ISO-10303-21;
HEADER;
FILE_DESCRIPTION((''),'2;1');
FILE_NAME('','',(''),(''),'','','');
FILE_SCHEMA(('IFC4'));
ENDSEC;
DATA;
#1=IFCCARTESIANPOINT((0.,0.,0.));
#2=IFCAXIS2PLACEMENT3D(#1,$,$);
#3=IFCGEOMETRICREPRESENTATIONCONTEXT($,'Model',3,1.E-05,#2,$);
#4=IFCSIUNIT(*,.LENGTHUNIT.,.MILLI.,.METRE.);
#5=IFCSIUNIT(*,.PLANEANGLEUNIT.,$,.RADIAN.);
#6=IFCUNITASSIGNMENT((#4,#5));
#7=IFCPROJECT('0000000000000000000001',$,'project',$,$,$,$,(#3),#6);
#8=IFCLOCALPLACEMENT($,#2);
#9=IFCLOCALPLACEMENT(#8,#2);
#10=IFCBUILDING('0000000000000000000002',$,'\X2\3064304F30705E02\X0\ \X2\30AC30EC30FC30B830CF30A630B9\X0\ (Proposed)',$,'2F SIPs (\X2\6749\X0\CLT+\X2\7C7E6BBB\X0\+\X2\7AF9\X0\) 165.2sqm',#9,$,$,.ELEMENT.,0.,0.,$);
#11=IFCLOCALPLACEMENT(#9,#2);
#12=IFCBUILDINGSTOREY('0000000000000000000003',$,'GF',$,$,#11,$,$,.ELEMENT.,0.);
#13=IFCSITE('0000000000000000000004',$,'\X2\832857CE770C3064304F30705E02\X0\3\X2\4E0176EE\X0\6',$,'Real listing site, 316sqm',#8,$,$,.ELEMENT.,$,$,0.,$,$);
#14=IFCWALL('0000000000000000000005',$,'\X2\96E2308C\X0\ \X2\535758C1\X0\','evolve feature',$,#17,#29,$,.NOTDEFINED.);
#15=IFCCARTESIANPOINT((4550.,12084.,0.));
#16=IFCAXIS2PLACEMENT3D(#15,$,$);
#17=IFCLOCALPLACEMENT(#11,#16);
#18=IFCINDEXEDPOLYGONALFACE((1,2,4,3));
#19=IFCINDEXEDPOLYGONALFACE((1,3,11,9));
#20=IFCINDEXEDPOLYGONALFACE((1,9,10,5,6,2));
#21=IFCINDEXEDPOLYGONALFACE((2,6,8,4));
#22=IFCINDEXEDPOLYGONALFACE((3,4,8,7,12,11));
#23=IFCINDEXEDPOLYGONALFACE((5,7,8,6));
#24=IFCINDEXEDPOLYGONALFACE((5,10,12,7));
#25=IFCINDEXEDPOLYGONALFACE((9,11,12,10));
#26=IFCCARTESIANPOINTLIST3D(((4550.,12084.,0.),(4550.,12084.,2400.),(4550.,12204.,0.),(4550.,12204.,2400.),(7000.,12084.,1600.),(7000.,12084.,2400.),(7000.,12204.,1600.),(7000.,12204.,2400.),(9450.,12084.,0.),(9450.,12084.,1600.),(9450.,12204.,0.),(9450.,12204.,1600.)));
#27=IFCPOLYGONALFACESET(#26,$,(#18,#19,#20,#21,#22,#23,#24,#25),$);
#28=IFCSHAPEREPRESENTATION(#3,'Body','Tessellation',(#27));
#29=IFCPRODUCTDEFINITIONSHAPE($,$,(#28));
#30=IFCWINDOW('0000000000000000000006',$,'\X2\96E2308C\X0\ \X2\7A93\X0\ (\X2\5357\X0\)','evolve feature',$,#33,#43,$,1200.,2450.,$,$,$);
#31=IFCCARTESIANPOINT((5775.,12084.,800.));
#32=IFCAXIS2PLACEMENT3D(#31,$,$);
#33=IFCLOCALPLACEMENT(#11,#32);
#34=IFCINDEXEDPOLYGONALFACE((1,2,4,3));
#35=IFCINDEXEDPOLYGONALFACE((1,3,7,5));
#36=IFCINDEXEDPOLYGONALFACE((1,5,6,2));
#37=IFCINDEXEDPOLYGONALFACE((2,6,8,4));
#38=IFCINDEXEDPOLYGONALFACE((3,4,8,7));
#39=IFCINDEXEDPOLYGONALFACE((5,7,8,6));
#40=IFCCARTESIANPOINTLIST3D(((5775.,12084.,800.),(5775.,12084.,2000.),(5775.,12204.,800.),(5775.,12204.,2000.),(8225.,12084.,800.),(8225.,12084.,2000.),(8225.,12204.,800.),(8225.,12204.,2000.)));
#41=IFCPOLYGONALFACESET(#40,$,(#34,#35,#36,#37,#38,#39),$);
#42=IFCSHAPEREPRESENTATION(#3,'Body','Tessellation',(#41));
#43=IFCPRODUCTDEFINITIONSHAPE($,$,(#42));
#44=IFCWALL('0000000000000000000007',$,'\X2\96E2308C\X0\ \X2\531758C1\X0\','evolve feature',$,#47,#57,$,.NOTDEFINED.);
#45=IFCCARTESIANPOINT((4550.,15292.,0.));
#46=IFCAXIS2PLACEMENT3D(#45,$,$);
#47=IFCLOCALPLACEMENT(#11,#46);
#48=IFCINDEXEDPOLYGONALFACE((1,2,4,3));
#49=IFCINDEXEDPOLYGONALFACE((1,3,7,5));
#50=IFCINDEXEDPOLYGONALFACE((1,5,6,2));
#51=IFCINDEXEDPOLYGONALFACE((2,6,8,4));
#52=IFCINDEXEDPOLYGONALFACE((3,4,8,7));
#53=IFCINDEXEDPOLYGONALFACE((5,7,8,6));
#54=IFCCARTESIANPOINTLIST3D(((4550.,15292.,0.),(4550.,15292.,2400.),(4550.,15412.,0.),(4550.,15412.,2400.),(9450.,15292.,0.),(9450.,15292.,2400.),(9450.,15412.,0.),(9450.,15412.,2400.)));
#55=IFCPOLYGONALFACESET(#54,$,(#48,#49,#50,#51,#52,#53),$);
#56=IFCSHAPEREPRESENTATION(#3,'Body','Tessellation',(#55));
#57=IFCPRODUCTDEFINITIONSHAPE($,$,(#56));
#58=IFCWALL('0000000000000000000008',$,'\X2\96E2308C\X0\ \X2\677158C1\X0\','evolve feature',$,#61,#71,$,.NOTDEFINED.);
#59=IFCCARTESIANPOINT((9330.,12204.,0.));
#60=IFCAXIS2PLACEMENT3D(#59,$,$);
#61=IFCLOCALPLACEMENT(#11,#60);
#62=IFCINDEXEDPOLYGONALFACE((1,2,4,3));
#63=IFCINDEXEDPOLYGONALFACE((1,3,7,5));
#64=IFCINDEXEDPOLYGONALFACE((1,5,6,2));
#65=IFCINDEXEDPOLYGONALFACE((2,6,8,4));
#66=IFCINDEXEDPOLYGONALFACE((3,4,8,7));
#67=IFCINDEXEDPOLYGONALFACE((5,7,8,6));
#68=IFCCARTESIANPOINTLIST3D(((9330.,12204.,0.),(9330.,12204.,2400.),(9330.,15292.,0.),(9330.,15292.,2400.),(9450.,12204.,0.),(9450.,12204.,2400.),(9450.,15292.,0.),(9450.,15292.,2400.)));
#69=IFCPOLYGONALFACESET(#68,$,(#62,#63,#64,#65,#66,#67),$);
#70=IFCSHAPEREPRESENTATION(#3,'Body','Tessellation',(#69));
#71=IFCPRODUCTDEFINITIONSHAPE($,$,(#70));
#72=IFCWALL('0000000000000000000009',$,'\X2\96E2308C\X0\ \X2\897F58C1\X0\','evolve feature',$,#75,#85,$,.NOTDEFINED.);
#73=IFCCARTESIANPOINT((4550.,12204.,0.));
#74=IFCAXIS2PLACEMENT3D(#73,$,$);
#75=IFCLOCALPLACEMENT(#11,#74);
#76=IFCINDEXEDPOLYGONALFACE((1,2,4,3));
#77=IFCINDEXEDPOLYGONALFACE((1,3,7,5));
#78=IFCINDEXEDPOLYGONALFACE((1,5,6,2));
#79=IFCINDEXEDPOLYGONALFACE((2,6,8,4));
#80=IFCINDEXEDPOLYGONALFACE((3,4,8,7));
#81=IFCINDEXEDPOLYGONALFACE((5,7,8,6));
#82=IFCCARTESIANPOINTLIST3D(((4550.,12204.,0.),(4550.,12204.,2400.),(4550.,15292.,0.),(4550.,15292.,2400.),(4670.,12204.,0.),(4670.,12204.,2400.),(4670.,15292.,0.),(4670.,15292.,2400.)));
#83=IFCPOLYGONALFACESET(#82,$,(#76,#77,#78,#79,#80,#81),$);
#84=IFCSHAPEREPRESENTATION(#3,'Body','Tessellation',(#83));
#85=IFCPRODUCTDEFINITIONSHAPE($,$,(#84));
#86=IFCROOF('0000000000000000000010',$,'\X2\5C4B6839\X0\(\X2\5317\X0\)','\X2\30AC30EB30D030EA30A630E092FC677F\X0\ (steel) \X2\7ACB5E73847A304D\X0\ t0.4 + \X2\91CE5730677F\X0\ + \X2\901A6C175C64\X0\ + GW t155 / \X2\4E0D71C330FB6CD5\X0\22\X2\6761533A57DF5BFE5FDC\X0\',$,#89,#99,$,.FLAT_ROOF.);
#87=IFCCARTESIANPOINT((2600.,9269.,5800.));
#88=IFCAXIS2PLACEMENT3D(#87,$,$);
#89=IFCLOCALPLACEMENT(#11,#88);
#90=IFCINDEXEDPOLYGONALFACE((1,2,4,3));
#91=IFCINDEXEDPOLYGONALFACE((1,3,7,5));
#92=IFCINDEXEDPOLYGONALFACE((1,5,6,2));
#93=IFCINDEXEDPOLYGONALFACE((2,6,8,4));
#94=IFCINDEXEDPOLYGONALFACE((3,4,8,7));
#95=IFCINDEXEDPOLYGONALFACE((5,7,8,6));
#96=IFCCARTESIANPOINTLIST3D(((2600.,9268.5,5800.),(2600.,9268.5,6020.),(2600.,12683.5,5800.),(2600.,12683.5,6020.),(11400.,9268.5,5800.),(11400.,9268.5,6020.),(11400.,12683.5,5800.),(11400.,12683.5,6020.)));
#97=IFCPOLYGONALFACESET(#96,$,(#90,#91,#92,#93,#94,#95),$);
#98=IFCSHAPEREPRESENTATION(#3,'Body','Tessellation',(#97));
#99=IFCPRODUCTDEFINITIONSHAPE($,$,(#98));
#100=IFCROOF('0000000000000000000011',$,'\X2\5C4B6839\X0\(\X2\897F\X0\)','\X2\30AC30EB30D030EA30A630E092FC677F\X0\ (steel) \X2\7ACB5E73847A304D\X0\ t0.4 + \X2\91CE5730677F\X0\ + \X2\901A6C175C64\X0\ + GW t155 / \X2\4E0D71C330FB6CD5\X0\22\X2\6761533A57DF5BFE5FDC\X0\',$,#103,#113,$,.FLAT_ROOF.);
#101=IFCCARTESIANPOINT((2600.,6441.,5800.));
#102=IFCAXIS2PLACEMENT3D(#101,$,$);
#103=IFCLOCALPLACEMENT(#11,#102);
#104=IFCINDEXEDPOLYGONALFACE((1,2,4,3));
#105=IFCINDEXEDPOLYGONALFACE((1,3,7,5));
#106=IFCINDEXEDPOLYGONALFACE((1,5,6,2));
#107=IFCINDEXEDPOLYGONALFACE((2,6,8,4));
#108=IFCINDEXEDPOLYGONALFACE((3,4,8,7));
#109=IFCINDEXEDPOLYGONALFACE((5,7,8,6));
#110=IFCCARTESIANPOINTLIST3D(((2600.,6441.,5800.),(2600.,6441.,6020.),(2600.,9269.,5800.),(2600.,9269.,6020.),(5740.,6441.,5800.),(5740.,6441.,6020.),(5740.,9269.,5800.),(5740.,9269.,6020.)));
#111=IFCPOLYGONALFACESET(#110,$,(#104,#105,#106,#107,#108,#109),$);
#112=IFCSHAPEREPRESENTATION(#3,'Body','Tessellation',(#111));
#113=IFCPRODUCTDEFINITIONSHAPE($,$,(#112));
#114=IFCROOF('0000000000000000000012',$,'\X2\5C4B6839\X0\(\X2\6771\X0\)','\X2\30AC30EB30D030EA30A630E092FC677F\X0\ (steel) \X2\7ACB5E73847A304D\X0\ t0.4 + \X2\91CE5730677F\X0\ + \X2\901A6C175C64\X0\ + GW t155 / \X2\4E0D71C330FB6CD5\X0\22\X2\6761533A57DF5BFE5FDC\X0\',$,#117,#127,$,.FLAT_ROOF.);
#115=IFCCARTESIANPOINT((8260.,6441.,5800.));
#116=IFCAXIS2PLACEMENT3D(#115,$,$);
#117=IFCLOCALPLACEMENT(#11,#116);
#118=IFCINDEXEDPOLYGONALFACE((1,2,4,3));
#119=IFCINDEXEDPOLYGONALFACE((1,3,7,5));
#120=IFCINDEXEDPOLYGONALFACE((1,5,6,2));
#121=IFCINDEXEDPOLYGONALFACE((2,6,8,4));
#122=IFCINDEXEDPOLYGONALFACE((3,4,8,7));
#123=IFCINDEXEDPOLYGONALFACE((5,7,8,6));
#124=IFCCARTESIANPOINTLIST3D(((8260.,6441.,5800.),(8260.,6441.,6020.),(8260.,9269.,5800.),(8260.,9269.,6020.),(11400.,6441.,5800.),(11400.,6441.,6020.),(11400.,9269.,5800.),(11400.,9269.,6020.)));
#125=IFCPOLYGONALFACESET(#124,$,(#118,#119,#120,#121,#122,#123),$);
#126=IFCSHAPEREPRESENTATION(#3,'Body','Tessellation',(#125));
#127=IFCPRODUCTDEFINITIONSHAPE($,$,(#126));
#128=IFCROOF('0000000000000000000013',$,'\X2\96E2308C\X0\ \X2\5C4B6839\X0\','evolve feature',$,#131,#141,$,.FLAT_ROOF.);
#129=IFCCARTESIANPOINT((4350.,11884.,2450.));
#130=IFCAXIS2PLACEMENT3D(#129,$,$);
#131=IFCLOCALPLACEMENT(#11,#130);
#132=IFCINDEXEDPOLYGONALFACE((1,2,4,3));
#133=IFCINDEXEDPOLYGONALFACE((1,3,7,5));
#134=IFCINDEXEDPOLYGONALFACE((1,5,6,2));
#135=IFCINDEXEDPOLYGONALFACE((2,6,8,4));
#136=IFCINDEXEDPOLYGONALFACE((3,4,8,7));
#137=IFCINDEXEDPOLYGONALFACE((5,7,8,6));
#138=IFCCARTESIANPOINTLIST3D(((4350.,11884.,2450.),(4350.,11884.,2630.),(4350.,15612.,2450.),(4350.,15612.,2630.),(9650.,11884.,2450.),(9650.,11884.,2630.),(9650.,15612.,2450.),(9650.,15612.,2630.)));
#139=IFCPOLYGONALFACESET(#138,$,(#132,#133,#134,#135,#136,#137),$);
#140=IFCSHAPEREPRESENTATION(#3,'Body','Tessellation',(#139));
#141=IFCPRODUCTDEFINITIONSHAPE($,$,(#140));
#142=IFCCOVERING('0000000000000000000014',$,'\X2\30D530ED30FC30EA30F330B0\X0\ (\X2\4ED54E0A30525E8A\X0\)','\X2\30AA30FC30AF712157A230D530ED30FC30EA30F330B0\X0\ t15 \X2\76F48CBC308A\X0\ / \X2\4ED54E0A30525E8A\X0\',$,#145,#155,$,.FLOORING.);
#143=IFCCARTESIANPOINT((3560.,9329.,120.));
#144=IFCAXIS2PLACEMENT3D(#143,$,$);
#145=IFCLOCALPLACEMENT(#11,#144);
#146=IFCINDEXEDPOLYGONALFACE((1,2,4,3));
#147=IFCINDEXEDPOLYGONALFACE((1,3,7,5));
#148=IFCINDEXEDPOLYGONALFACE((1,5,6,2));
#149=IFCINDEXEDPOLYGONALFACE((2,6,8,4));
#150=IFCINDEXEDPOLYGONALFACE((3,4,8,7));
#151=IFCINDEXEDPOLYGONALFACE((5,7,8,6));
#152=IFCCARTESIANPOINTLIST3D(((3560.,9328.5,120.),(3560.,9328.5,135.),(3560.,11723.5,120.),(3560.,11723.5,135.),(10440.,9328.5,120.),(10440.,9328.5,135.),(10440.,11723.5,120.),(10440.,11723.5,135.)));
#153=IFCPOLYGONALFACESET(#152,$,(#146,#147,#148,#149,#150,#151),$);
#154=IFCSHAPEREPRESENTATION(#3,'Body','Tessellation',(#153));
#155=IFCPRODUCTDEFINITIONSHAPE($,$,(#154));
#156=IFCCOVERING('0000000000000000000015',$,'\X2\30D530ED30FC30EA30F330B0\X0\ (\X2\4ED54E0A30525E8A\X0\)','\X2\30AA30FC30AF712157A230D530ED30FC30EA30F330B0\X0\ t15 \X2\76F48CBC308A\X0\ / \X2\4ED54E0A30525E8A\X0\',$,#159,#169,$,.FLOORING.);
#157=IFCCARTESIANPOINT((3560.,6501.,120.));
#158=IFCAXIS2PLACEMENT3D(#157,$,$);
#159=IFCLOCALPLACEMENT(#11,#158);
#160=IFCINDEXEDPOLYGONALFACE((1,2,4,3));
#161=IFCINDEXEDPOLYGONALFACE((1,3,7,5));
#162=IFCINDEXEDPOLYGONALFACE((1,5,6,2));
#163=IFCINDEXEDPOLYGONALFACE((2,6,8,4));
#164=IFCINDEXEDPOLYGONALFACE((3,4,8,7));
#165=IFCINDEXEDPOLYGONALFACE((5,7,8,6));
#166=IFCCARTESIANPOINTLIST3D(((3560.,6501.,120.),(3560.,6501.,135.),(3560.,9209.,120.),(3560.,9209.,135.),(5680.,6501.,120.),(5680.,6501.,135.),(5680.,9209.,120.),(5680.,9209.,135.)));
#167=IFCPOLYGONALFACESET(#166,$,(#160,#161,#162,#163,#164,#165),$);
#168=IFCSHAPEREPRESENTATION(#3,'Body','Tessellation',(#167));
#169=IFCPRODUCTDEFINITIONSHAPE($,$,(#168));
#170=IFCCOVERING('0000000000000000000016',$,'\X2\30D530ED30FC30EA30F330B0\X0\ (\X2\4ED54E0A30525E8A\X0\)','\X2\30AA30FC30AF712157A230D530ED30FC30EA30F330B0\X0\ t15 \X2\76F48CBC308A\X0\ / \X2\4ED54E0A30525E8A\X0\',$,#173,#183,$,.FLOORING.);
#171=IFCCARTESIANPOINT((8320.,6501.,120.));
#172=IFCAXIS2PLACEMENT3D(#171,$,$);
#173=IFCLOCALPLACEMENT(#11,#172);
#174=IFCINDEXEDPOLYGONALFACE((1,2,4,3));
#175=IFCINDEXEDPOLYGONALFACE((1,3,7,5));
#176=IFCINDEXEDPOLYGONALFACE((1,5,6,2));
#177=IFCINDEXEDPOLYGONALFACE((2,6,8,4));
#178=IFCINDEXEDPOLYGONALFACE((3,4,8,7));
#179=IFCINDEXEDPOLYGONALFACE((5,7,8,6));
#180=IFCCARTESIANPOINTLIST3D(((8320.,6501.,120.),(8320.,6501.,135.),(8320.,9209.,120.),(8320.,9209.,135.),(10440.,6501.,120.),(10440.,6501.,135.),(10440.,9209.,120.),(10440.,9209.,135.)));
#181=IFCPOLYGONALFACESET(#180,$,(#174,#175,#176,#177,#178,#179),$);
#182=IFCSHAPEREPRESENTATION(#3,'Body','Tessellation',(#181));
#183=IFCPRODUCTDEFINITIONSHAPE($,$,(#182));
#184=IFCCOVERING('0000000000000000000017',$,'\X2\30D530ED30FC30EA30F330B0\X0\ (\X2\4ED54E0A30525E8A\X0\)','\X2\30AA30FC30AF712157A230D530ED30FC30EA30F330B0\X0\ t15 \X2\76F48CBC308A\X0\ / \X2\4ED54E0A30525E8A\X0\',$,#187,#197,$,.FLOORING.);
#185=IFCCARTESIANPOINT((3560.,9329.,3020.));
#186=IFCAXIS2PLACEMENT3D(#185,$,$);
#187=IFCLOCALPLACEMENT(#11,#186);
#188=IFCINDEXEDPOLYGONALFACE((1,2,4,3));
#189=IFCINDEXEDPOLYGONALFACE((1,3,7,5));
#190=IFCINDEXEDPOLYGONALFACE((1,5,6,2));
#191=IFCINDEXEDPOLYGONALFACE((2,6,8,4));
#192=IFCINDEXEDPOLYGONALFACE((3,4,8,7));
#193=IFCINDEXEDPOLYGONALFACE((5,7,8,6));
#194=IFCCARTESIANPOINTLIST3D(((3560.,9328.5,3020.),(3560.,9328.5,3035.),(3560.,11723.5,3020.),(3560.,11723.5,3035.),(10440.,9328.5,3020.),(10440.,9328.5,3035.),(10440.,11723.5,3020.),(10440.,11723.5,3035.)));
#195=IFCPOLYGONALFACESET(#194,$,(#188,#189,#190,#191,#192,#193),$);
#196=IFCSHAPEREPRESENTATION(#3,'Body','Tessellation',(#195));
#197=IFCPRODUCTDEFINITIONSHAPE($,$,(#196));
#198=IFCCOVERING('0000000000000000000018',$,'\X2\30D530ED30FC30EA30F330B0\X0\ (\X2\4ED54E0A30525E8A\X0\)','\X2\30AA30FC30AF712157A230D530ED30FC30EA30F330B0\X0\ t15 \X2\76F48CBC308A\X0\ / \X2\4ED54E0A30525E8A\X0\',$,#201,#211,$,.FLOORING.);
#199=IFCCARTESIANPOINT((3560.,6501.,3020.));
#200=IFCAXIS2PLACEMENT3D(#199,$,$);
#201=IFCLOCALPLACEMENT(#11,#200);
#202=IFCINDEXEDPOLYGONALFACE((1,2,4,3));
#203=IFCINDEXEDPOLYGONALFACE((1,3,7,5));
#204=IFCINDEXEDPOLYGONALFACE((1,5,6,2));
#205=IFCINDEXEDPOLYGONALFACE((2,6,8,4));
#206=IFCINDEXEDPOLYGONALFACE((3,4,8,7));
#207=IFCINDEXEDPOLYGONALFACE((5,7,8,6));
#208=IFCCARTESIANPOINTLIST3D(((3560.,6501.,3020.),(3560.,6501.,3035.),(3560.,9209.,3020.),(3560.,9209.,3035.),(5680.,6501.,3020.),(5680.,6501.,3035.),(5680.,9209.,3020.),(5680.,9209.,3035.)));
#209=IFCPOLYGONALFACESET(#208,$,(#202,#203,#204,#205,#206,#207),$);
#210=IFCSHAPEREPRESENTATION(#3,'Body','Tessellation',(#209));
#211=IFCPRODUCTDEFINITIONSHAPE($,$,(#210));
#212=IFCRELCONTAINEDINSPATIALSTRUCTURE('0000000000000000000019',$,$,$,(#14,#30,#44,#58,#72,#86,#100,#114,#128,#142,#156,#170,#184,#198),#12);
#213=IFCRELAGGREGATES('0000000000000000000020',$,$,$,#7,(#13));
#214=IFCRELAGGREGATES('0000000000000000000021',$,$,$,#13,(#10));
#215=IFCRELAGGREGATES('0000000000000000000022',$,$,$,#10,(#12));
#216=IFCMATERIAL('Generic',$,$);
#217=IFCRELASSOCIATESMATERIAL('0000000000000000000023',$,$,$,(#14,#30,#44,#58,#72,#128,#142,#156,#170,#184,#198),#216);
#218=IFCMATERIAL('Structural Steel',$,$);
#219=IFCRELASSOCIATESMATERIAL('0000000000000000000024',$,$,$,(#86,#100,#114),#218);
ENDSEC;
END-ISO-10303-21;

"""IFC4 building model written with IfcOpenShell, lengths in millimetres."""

from ifc_helpers import new_model, si_unit, frame, frame_2d, origin, place, context, project, spatial, rectangle, extrude, material, element, fill, save


model = new_model("IFC4")

# Units and contexts
model_context = context("Model", 3, precision=1e-05, world=origin())
ifc_project = project(units=[si_unit("LENGTHUNIT", "METRE", prefix="MILLI"), si_unit("PLANEANGLEUNIT", "RADIAN")], contexts=[model_context])

# Site, building, storey
site_placement = place(None, origin())
site = spatial("IfcSite", under=ifc_project, at=site_placement, Name="茨城県つくば市3丁目6", ObjectType="Real listing site, 316sqm", CompositionType="ELEMENT", RefElevation=0.0)
building_placement = place(site_placement, origin())
building = spatial("IfcBuilding", under=site, at=building_placement, Name="つくば市 ガレージハウス (Proposed)", ObjectType="2F SIPs (杉CLT+籾殻+竹) 165.2sqm", CompositionType="ELEMENT", ElevationOfRefHeight=0.0, ElevationOfTerrain=0.0)
storey_placement = place(building_placement, origin())
storey = spatial("IfcBuildingStorey", under=building, at=storey_placement, Name="GF", CompositionType="ELEMENT", Elevation=0.0)

# Shared definitions
ifc_material_1 = material(Name="Generic")

# Wall, opening, window
wall_1_placement = place(storey_placement, frame((4550.0, 12084.0, 0.0)))
wall_1 = element("IfcWall", 1, at=wall_1_placement, inside=storey, material=ifc_material_1, Name="離れ 南壁", Description="evolve feature", PredefinedType="NOTDEFINED", context=model_context, shape_type="SweptSolid", body=[
    extrude(rectangle(XDim=4900.0, YDim=120.0, at=frame_2d((2450.0, 60.0))), frame((4550.0, 12084.0, 0.0)), (0.0, 0.0, 1.0), 2400.0),
])
opening_1_placement = place(storey_placement, frame((5775.0, 12084.0, 800.0)))
opening_1 = element("IfcOpeningElement", 2, at=opening_1_placement, cuts=wall_1, PredefinedType="NOTDEFINED", context=model_context, shape_type="SweptSolid", body=[
    extrude(rectangle(XDim=2450.0, YDim=120.0, at=frame_2d((1225.0, 60.0))), frame((5775.0, 12084.0, 800.0)), (0.0, 0.0, 1.0), 1200.0),
])
window_1_placement = place(storey_placement, frame((5775.0, 12084.0, 800.0)))
window_1 = element("IfcWindow", 3, at=window_1_placement, inside=storey, material=ifc_material_1, Name="離れ 窓 (南)", Description="evolve feature", OverallHeight=1200.0, OverallWidth=2450.0, context=model_context, shape_type="SweptSolid", body=[
    extrude(rectangle(XDim=2450.0, YDim=120.0, at=frame_2d((1225.0, 60.0))), frame((5775.0, 12084.0, 800.0)), (0.0, 0.0, 1.0), 1200.0),
])
fill(opening_1, window_1)

# Walls
wall_2_placement = place(storey_placement, frame((4550.0, 15292.0, 0.0)))
element("IfcWall", 4, at=wall_2_placement, inside=storey, material=ifc_material_1, Name="離れ 北壁", Description="evolve feature", PredefinedType="NOTDEFINED", context=model_context, shape_type="SweptSolid", body=[
    extrude(rectangle(XDim=4900.0, YDim=120.0, at=frame_2d((2450.0, 60.0))), frame((4550.0, 15292.0, 0.0)), (0.0, 0.0, 1.0), 2400.0),
])
wall_3_placement = place(storey_placement, frame((9330.0, 12204.0, 0.0)))
element("IfcWall", 5, at=wall_3_placement, inside=storey, material=ifc_material_1, Name="離れ 東壁", Description="evolve feature", PredefinedType="NOTDEFINED", context=model_context, shape_type="SweptSolid", body=[
    extrude(rectangle(XDim=120.0, YDim=3088.0, at=frame_2d((60.0, 1544.0))), frame((9330.0, 12204.0, 0.0)), (0.0, 0.0, 1.0), 2400.0),
])
wall_4_placement = place(storey_placement, frame((4550.0, 12204.0, 0.0)))
element("IfcWall", 6, at=wall_4_placement, inside=storey, material=ifc_material_1, Name="離れ 西壁", Description="evolve feature", PredefinedType="NOTDEFINED", context=model_context, shape_type="SweptSolid", body=[
    extrude(rectangle(XDim=120.0, YDim=3088.0, at=frame_2d((60.0, 1544.0))), frame((4550.0, 12204.0, 0.0)), (0.0, 0.0, 1.0), 2400.0),
])

# Roofs
ifc_material_2 = material(Name="Structural Steel")
for number, where, name in (
    (7, (2600.0, 9269.0, 5800.0), "屋根(北)"),
):
    element("IfcRoof", number, at=place(storey_placement, frame(where)), inside=storey, material=ifc_material_2, Name=name, Description="ガルバリウム鋼板 (steel) 立平葺き t0.4 + 野地板 + 通気層 + GW t155 / 不燃・法22条区域対応", PredefinedType="FLAT_ROOF", context=model_context, shape_type="SweptSolid", body=[
        extrude(rectangle(XDim=8800.0, YDim=3415.0, at=frame_2d((4400.0, 1707.0))), frame((2600.0, 9269.0, 5800.0)), (0.0, 0.0, 1.0), 220.0),
    ])
roof_1_placement = place(storey_placement, frame((2600.0, 6441.0, 5800.0)))
element("IfcRoof", 8, at=roof_1_placement, inside=storey, material=ifc_material_2, Name="屋根(西)", Description="ガルバリウム鋼板 (steel) 立平葺き t0.4 + 野地板 + 通気層 + GW t155 / 不燃・法22条区域対応", PredefinedType="FLAT_ROOF", context=model_context, shape_type="SweptSolid", body=[
    extrude(rectangle(XDim=3140.0, YDim=2828.0, at=frame_2d((1570.0, 1414.0))), frame((2600.0, 6441.0, 5800.0)), (0.0, 0.0, 1.0), 220.0),
])
roof_2_placement = place(storey_placement, frame((8260.0, 6441.0, 5800.0)))
element("IfcRoof", 9, at=roof_2_placement, inside=storey, material=ifc_material_2, Name="屋根(東)", Description="ガルバリウム鋼板 (steel) 立平葺き t0.4 + 野地板 + 通気層 + GW t155 / 不燃・法22条区域対応", PredefinedType="FLAT_ROOF", context=model_context, shape_type="SweptSolid", body=[
    extrude(rectangle(XDim=3140.0, YDim=2828.0, at=frame_2d((1570.0, 1414.0))), frame((8260.0, 6441.0, 5800.0)), (0.0, 0.0, 1.0), 220.0),
])
roof_3_placement = place(storey_placement, frame((4350.0, 11884.0, 2450.0)))
element("IfcRoof", 10, at=roof_3_placement, inside=storey, material=ifc_material_1, Name="離れ 屋根", Description="evolve feature", PredefinedType="FLAT_ROOF", context=model_context, shape_type="SweptSolid", body=[
    extrude(rectangle(XDim=5300.0, YDim=3728.0, at=frame_2d((2650.0, 1864.0))), frame((4350.0, 11884.0, 2450.0)), (0.0, 0.0, 1.0), 180.0),
])

# Coverings
covering_1_placement = place(storey_placement, frame((3560.0, 9329.0, 120.0)))
element("IfcCovering", 11, at=covering_1_placement, inside=storey, material=ifc_material_1, Name="フローリング (仕上げ床)", Description="オーク無垢フローリング t15 直貼り / 仕上げ床", PredefinedType="FLOORING", context=model_context, shape_type="SweptSolid", body=[
    extrude(rectangle(XDim=6880.0, YDim=2395.0, at=frame_2d((3440.0, 1197.0))), frame((3560.0, 9329.0, 120.0)), (0.0, 0.0, 1.0), 15.0),
])
covering_2_placement = place(storey_placement, frame((3560.0, 6501.0, 120.0)))
element("IfcCovering", 12, at=covering_2_placement, inside=storey, material=ifc_material_1, Name="フローリング (仕上げ床)", Description="オーク無垢フローリング t15 直貼り / 仕上げ床", PredefinedType="FLOORING", context=model_context, shape_type="SweptSolid", body=[
    extrude(rectangle(XDim=2120.0, YDim=2708.0, at=frame_2d((1060.0, 1354.0))), frame((3560.0, 6501.0, 120.0)), (0.0, 0.0, 1.0), 15.0),
])
covering_3_placement = place(storey_placement, frame((8320.0, 6501.0, 120.0)))
element("IfcCovering", 13, at=covering_3_placement, inside=storey, material=ifc_material_1, Name="フローリング (仕上げ床)", Description="オーク無垢フローリング t15 直貼り / 仕上げ床", PredefinedType="FLOORING", context=model_context, shape_type="SweptSolid", body=[
    extrude(rectangle(XDim=2120.0, YDim=2708.0, at=frame_2d((1060.0, 1354.0))), frame((8320.0, 6501.0, 120.0)), (0.0, 0.0, 1.0), 15.0),
])
covering_4_placement = place(storey_placement, frame((3560.0, 9329.0, 3020.0)))
element("IfcCovering", 14, at=covering_4_placement, inside=storey, material=ifc_material_1, Name="フローリング (仕上げ床)", Description="オーク無垢フローリング t15 直貼り / 仕上げ床", PredefinedType="FLOORING", context=model_context, shape_type="SweptSolid", body=[
    extrude(rectangle(XDim=6880.0, YDim=2395.0, at=frame_2d((3440.0, 1197.0))), frame((3560.0, 9329.0, 3020.0)), (0.0, 0.0, 1.0), 15.0),
])
covering_5_placement = place(storey_placement, frame((3560.0, 6501.0, 3020.0)))
element("IfcCovering", 15, at=covering_5_placement, inside=storey, material=ifc_material_1, Name="フローリング (仕上げ床)", Description="オーク無垢フローリング t15 直貼り / 仕上げ床", PredefinedType="FLOORING", context=model_context, shape_type="SweptSolid", body=[
    extrude(rectangle(XDim=2120.0, YDim=2708.0, at=frame_2d((1060.0, 1354.0))), frame((3560.0, 6501.0, 3020.0)), (0.0, 0.0, 1.0), 15.0),
])

save(model, "model.ifc")
